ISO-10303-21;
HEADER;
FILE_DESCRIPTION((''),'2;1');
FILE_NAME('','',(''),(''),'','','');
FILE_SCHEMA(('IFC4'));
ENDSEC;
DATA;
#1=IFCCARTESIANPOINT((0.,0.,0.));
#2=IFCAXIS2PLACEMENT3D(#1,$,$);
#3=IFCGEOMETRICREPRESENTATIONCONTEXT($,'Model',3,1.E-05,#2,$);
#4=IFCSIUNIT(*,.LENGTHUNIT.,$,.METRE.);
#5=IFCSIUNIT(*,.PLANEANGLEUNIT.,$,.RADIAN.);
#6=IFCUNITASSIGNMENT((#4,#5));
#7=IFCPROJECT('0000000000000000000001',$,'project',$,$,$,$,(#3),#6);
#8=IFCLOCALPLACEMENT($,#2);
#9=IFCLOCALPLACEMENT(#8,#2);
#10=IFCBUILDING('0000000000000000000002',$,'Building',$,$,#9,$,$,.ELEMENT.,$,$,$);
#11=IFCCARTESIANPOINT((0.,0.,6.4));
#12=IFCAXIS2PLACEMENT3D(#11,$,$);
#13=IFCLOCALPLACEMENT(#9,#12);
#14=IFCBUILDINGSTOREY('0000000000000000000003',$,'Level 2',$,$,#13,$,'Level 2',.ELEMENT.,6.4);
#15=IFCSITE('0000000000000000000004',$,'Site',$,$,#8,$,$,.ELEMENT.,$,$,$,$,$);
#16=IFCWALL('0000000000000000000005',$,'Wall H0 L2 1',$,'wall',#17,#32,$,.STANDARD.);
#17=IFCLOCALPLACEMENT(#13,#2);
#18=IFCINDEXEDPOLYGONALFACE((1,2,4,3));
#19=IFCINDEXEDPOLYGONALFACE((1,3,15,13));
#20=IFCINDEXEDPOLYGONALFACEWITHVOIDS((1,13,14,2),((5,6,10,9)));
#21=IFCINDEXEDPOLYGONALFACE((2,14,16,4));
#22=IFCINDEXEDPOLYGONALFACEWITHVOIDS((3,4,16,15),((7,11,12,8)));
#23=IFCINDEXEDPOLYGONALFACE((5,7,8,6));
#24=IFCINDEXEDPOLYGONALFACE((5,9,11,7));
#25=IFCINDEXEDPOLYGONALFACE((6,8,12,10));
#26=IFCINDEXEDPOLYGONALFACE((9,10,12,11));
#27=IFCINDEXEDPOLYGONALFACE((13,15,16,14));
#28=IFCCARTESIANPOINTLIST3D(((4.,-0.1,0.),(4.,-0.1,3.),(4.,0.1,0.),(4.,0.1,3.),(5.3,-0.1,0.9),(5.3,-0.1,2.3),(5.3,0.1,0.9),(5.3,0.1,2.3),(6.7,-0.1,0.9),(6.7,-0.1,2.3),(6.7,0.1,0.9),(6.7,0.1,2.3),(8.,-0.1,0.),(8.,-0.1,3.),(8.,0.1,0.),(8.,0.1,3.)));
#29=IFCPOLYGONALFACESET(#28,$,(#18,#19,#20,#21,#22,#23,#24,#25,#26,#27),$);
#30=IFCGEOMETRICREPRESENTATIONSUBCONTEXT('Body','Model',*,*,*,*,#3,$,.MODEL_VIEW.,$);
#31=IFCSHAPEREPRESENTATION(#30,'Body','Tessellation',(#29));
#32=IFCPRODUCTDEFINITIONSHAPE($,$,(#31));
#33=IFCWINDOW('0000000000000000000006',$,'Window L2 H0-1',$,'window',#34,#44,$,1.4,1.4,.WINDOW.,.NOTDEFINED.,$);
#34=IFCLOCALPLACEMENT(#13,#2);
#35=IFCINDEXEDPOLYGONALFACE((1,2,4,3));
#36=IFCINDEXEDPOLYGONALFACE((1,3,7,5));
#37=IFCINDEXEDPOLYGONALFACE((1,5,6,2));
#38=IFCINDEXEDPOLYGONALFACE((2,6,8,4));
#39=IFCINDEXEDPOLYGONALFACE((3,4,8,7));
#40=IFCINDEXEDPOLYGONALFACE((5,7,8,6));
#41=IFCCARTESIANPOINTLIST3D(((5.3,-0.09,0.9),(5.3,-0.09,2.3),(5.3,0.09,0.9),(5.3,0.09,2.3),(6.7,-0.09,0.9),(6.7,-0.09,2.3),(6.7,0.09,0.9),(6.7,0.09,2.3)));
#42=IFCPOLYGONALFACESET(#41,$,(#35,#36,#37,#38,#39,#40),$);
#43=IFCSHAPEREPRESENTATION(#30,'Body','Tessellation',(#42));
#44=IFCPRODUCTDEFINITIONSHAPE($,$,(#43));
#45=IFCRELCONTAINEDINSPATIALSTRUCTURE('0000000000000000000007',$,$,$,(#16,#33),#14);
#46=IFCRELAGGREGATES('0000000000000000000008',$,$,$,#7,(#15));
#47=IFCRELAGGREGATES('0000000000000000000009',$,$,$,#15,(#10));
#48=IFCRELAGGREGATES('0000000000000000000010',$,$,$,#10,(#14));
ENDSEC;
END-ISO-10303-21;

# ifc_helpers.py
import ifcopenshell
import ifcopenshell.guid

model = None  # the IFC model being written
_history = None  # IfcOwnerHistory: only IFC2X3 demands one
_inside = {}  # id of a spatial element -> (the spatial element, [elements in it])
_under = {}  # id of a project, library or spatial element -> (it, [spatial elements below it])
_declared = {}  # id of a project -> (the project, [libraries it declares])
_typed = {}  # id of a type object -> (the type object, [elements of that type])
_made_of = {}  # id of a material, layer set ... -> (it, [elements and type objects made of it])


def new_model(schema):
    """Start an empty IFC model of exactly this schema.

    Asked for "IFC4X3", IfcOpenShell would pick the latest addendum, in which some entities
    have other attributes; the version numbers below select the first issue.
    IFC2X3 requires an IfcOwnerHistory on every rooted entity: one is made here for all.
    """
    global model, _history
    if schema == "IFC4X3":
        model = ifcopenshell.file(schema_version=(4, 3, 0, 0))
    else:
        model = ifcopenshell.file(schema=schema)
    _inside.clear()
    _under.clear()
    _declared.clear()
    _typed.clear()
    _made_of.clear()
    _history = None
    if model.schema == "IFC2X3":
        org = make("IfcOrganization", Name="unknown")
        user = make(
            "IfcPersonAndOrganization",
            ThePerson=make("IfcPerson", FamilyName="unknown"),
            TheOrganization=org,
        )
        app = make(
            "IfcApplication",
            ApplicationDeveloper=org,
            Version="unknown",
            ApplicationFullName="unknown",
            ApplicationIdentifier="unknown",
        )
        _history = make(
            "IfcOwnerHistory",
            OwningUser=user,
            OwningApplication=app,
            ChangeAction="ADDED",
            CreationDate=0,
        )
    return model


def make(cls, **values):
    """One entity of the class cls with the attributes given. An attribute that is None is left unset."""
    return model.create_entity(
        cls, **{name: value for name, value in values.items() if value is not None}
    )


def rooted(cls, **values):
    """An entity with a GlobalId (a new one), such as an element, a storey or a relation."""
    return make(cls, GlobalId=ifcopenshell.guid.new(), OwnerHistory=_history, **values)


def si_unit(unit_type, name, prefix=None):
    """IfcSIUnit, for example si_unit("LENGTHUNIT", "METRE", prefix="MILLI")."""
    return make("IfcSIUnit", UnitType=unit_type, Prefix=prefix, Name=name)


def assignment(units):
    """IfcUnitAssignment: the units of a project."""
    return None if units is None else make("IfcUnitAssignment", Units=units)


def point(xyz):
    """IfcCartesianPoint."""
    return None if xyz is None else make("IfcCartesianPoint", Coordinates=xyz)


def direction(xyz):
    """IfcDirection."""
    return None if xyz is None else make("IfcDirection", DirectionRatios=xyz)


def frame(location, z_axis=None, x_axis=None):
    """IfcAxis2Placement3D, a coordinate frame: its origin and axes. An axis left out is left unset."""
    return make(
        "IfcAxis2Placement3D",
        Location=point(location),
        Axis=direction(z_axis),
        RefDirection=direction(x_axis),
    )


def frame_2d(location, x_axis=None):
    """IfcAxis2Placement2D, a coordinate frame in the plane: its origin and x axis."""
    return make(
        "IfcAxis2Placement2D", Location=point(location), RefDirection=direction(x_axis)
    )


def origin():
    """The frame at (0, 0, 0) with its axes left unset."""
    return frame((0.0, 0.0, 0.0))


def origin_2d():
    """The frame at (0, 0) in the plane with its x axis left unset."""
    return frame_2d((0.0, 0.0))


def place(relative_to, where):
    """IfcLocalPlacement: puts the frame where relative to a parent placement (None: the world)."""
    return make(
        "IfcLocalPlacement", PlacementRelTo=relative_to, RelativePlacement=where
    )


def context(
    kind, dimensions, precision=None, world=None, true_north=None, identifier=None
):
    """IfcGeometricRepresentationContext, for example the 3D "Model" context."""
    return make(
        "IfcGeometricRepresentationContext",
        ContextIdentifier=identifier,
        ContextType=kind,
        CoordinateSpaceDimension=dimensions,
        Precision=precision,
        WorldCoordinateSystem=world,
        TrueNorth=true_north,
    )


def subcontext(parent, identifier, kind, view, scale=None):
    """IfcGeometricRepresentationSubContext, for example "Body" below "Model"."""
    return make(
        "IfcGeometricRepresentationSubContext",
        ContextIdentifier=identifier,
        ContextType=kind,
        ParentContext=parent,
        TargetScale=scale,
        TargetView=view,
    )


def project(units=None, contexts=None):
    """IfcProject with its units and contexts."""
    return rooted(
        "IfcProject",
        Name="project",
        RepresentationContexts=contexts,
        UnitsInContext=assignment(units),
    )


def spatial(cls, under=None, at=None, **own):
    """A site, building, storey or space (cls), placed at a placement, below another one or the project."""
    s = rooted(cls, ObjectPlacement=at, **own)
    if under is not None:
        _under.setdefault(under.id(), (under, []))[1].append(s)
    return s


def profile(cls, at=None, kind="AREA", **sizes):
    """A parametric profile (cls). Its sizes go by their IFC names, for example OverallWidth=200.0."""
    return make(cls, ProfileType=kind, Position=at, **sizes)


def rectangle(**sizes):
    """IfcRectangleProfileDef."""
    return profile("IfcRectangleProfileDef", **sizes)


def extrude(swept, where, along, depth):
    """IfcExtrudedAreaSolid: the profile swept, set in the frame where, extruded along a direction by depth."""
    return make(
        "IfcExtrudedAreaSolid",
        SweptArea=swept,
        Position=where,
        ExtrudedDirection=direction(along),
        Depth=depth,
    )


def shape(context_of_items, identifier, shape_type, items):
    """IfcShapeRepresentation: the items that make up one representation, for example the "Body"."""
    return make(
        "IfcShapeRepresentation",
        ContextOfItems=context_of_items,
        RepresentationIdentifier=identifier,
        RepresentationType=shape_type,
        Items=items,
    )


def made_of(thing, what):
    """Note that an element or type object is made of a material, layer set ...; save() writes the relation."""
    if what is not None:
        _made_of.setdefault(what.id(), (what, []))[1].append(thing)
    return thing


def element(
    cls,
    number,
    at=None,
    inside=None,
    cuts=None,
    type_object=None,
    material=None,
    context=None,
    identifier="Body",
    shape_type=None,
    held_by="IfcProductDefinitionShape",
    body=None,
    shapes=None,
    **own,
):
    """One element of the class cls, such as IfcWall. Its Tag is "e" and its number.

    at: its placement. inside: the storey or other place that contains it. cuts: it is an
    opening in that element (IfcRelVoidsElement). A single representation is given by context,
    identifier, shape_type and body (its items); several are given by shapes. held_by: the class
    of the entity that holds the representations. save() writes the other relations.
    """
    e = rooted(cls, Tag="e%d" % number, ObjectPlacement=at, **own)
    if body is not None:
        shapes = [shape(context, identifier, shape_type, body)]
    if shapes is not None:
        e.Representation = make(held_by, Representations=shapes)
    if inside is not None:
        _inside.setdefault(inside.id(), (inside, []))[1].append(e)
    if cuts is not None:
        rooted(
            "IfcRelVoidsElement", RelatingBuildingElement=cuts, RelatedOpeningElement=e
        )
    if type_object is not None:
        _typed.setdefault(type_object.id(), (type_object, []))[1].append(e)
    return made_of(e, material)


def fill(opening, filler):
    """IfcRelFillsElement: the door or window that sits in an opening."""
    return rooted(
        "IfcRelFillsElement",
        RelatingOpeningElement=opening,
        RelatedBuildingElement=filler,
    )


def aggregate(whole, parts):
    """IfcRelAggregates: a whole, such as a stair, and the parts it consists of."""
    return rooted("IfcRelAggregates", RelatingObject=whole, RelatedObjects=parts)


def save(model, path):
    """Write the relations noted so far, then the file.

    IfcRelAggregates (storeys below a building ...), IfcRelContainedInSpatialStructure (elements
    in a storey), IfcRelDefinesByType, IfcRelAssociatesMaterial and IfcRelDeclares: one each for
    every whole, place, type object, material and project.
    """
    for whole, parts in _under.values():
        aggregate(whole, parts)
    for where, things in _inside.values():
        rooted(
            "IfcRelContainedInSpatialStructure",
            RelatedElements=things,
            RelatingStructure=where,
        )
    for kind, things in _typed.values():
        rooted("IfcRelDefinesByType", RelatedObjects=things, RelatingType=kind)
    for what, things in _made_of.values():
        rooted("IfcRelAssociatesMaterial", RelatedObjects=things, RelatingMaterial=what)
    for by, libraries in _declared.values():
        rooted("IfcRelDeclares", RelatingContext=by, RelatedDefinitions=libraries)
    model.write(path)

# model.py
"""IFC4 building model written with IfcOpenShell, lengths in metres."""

from ifc_helpers import new_model, si_unit, frame, frame_2d, origin, origin_2d, place, context, subcontext, project, spatial, rectangle, extrude, element, fill, save


model = new_model("IFC4")

# Units and contexts
model_context = context("Model", 3, precision=1e-05, world=origin())
body_context = subcontext(model_context, "Body", "Model", "MODEL_VIEW")
ifc_project = project(units=[si_unit("LENGTHUNIT", "METRE"), si_unit("PLANEANGLEUNIT", "RADIAN")], contexts=[model_context])

# Site, building, storey
site_placement = place(None, origin())
site = spatial("IfcSite", under=ifc_project, at=site_placement, Name="Site", CompositionType="ELEMENT")
building_placement = place(site_placement, origin())
building = spatial("IfcBuilding", under=site, at=building_placement, Name="Building", CompositionType="ELEMENT")
storey_placement = place(building_placement, frame((0.0, 0.0, 6.4)))
storey = spatial("IfcBuildingStorey", under=building, at=storey_placement, Name="Level 2", LongName="Level 2", CompositionType="ELEMENT", Elevation=6.4)

# Wall, opening, window
wall_1_placement = place(storey_placement, frame((4.0, 0.0, 0.0), z_axis=(0.0, 0.0, 1.0), x_axis=(1.0, 0.0, 0.0)))
wall_1 = element("IfcWall", 1, at=wall_1_placement, inside=storey, Name="Wall H0 L2 1", ObjectType="wall", PredefinedType="STANDARD", context=body_context, shape_type="SweptSolid", body=[
    extrude(rectangle(XDim=4.0, YDim=0.2, at=frame_2d((2.0, 0.0))), origin(), (0.0, 0.0, 1.0), 3.0),
])
opening_placement = place(storey_placement, frame((6.0, 0.0, 0.9), z_axis=(0.0, 0.0, 1.0), x_axis=(1.0, 0.0, 0.0)))
opening = element("IfcOpeningElement", 2, at=opening_placement, cuts=wall_1, ObjectType="Opening", PredefinedType="OPENING", context=body_context, shape_type="SweptSolid", body=[
    extrude(rectangle(XDim=1.4, YDim=0.22, at=origin_2d()), origin(), (0.0, 0.0, 1.0), 1.4),
])
window_placement = place(storey_placement, frame((6.0, 0.0, 0.9), z_axis=(0.0, 0.0, 1.0), x_axis=(1.0, 0.0, 0.0)))
window = element("IfcWindow", 3, at=window_placement, inside=storey, Name="Window L2 H0-1", ObjectType="window", OverallHeight=1.4, OverallWidth=1.4, PartitioningType="NOTDEFINED", PredefinedType="WINDOW", context=body_context, shape_type="SweptSolid", body=[
    extrude(rectangle(XDim=1.4, YDim=0.18, at=origin_2d()), origin(), (0.0, 0.0, 1.0), 1.4),
])
fill(opening, window)

save(model, "model.ifc")
